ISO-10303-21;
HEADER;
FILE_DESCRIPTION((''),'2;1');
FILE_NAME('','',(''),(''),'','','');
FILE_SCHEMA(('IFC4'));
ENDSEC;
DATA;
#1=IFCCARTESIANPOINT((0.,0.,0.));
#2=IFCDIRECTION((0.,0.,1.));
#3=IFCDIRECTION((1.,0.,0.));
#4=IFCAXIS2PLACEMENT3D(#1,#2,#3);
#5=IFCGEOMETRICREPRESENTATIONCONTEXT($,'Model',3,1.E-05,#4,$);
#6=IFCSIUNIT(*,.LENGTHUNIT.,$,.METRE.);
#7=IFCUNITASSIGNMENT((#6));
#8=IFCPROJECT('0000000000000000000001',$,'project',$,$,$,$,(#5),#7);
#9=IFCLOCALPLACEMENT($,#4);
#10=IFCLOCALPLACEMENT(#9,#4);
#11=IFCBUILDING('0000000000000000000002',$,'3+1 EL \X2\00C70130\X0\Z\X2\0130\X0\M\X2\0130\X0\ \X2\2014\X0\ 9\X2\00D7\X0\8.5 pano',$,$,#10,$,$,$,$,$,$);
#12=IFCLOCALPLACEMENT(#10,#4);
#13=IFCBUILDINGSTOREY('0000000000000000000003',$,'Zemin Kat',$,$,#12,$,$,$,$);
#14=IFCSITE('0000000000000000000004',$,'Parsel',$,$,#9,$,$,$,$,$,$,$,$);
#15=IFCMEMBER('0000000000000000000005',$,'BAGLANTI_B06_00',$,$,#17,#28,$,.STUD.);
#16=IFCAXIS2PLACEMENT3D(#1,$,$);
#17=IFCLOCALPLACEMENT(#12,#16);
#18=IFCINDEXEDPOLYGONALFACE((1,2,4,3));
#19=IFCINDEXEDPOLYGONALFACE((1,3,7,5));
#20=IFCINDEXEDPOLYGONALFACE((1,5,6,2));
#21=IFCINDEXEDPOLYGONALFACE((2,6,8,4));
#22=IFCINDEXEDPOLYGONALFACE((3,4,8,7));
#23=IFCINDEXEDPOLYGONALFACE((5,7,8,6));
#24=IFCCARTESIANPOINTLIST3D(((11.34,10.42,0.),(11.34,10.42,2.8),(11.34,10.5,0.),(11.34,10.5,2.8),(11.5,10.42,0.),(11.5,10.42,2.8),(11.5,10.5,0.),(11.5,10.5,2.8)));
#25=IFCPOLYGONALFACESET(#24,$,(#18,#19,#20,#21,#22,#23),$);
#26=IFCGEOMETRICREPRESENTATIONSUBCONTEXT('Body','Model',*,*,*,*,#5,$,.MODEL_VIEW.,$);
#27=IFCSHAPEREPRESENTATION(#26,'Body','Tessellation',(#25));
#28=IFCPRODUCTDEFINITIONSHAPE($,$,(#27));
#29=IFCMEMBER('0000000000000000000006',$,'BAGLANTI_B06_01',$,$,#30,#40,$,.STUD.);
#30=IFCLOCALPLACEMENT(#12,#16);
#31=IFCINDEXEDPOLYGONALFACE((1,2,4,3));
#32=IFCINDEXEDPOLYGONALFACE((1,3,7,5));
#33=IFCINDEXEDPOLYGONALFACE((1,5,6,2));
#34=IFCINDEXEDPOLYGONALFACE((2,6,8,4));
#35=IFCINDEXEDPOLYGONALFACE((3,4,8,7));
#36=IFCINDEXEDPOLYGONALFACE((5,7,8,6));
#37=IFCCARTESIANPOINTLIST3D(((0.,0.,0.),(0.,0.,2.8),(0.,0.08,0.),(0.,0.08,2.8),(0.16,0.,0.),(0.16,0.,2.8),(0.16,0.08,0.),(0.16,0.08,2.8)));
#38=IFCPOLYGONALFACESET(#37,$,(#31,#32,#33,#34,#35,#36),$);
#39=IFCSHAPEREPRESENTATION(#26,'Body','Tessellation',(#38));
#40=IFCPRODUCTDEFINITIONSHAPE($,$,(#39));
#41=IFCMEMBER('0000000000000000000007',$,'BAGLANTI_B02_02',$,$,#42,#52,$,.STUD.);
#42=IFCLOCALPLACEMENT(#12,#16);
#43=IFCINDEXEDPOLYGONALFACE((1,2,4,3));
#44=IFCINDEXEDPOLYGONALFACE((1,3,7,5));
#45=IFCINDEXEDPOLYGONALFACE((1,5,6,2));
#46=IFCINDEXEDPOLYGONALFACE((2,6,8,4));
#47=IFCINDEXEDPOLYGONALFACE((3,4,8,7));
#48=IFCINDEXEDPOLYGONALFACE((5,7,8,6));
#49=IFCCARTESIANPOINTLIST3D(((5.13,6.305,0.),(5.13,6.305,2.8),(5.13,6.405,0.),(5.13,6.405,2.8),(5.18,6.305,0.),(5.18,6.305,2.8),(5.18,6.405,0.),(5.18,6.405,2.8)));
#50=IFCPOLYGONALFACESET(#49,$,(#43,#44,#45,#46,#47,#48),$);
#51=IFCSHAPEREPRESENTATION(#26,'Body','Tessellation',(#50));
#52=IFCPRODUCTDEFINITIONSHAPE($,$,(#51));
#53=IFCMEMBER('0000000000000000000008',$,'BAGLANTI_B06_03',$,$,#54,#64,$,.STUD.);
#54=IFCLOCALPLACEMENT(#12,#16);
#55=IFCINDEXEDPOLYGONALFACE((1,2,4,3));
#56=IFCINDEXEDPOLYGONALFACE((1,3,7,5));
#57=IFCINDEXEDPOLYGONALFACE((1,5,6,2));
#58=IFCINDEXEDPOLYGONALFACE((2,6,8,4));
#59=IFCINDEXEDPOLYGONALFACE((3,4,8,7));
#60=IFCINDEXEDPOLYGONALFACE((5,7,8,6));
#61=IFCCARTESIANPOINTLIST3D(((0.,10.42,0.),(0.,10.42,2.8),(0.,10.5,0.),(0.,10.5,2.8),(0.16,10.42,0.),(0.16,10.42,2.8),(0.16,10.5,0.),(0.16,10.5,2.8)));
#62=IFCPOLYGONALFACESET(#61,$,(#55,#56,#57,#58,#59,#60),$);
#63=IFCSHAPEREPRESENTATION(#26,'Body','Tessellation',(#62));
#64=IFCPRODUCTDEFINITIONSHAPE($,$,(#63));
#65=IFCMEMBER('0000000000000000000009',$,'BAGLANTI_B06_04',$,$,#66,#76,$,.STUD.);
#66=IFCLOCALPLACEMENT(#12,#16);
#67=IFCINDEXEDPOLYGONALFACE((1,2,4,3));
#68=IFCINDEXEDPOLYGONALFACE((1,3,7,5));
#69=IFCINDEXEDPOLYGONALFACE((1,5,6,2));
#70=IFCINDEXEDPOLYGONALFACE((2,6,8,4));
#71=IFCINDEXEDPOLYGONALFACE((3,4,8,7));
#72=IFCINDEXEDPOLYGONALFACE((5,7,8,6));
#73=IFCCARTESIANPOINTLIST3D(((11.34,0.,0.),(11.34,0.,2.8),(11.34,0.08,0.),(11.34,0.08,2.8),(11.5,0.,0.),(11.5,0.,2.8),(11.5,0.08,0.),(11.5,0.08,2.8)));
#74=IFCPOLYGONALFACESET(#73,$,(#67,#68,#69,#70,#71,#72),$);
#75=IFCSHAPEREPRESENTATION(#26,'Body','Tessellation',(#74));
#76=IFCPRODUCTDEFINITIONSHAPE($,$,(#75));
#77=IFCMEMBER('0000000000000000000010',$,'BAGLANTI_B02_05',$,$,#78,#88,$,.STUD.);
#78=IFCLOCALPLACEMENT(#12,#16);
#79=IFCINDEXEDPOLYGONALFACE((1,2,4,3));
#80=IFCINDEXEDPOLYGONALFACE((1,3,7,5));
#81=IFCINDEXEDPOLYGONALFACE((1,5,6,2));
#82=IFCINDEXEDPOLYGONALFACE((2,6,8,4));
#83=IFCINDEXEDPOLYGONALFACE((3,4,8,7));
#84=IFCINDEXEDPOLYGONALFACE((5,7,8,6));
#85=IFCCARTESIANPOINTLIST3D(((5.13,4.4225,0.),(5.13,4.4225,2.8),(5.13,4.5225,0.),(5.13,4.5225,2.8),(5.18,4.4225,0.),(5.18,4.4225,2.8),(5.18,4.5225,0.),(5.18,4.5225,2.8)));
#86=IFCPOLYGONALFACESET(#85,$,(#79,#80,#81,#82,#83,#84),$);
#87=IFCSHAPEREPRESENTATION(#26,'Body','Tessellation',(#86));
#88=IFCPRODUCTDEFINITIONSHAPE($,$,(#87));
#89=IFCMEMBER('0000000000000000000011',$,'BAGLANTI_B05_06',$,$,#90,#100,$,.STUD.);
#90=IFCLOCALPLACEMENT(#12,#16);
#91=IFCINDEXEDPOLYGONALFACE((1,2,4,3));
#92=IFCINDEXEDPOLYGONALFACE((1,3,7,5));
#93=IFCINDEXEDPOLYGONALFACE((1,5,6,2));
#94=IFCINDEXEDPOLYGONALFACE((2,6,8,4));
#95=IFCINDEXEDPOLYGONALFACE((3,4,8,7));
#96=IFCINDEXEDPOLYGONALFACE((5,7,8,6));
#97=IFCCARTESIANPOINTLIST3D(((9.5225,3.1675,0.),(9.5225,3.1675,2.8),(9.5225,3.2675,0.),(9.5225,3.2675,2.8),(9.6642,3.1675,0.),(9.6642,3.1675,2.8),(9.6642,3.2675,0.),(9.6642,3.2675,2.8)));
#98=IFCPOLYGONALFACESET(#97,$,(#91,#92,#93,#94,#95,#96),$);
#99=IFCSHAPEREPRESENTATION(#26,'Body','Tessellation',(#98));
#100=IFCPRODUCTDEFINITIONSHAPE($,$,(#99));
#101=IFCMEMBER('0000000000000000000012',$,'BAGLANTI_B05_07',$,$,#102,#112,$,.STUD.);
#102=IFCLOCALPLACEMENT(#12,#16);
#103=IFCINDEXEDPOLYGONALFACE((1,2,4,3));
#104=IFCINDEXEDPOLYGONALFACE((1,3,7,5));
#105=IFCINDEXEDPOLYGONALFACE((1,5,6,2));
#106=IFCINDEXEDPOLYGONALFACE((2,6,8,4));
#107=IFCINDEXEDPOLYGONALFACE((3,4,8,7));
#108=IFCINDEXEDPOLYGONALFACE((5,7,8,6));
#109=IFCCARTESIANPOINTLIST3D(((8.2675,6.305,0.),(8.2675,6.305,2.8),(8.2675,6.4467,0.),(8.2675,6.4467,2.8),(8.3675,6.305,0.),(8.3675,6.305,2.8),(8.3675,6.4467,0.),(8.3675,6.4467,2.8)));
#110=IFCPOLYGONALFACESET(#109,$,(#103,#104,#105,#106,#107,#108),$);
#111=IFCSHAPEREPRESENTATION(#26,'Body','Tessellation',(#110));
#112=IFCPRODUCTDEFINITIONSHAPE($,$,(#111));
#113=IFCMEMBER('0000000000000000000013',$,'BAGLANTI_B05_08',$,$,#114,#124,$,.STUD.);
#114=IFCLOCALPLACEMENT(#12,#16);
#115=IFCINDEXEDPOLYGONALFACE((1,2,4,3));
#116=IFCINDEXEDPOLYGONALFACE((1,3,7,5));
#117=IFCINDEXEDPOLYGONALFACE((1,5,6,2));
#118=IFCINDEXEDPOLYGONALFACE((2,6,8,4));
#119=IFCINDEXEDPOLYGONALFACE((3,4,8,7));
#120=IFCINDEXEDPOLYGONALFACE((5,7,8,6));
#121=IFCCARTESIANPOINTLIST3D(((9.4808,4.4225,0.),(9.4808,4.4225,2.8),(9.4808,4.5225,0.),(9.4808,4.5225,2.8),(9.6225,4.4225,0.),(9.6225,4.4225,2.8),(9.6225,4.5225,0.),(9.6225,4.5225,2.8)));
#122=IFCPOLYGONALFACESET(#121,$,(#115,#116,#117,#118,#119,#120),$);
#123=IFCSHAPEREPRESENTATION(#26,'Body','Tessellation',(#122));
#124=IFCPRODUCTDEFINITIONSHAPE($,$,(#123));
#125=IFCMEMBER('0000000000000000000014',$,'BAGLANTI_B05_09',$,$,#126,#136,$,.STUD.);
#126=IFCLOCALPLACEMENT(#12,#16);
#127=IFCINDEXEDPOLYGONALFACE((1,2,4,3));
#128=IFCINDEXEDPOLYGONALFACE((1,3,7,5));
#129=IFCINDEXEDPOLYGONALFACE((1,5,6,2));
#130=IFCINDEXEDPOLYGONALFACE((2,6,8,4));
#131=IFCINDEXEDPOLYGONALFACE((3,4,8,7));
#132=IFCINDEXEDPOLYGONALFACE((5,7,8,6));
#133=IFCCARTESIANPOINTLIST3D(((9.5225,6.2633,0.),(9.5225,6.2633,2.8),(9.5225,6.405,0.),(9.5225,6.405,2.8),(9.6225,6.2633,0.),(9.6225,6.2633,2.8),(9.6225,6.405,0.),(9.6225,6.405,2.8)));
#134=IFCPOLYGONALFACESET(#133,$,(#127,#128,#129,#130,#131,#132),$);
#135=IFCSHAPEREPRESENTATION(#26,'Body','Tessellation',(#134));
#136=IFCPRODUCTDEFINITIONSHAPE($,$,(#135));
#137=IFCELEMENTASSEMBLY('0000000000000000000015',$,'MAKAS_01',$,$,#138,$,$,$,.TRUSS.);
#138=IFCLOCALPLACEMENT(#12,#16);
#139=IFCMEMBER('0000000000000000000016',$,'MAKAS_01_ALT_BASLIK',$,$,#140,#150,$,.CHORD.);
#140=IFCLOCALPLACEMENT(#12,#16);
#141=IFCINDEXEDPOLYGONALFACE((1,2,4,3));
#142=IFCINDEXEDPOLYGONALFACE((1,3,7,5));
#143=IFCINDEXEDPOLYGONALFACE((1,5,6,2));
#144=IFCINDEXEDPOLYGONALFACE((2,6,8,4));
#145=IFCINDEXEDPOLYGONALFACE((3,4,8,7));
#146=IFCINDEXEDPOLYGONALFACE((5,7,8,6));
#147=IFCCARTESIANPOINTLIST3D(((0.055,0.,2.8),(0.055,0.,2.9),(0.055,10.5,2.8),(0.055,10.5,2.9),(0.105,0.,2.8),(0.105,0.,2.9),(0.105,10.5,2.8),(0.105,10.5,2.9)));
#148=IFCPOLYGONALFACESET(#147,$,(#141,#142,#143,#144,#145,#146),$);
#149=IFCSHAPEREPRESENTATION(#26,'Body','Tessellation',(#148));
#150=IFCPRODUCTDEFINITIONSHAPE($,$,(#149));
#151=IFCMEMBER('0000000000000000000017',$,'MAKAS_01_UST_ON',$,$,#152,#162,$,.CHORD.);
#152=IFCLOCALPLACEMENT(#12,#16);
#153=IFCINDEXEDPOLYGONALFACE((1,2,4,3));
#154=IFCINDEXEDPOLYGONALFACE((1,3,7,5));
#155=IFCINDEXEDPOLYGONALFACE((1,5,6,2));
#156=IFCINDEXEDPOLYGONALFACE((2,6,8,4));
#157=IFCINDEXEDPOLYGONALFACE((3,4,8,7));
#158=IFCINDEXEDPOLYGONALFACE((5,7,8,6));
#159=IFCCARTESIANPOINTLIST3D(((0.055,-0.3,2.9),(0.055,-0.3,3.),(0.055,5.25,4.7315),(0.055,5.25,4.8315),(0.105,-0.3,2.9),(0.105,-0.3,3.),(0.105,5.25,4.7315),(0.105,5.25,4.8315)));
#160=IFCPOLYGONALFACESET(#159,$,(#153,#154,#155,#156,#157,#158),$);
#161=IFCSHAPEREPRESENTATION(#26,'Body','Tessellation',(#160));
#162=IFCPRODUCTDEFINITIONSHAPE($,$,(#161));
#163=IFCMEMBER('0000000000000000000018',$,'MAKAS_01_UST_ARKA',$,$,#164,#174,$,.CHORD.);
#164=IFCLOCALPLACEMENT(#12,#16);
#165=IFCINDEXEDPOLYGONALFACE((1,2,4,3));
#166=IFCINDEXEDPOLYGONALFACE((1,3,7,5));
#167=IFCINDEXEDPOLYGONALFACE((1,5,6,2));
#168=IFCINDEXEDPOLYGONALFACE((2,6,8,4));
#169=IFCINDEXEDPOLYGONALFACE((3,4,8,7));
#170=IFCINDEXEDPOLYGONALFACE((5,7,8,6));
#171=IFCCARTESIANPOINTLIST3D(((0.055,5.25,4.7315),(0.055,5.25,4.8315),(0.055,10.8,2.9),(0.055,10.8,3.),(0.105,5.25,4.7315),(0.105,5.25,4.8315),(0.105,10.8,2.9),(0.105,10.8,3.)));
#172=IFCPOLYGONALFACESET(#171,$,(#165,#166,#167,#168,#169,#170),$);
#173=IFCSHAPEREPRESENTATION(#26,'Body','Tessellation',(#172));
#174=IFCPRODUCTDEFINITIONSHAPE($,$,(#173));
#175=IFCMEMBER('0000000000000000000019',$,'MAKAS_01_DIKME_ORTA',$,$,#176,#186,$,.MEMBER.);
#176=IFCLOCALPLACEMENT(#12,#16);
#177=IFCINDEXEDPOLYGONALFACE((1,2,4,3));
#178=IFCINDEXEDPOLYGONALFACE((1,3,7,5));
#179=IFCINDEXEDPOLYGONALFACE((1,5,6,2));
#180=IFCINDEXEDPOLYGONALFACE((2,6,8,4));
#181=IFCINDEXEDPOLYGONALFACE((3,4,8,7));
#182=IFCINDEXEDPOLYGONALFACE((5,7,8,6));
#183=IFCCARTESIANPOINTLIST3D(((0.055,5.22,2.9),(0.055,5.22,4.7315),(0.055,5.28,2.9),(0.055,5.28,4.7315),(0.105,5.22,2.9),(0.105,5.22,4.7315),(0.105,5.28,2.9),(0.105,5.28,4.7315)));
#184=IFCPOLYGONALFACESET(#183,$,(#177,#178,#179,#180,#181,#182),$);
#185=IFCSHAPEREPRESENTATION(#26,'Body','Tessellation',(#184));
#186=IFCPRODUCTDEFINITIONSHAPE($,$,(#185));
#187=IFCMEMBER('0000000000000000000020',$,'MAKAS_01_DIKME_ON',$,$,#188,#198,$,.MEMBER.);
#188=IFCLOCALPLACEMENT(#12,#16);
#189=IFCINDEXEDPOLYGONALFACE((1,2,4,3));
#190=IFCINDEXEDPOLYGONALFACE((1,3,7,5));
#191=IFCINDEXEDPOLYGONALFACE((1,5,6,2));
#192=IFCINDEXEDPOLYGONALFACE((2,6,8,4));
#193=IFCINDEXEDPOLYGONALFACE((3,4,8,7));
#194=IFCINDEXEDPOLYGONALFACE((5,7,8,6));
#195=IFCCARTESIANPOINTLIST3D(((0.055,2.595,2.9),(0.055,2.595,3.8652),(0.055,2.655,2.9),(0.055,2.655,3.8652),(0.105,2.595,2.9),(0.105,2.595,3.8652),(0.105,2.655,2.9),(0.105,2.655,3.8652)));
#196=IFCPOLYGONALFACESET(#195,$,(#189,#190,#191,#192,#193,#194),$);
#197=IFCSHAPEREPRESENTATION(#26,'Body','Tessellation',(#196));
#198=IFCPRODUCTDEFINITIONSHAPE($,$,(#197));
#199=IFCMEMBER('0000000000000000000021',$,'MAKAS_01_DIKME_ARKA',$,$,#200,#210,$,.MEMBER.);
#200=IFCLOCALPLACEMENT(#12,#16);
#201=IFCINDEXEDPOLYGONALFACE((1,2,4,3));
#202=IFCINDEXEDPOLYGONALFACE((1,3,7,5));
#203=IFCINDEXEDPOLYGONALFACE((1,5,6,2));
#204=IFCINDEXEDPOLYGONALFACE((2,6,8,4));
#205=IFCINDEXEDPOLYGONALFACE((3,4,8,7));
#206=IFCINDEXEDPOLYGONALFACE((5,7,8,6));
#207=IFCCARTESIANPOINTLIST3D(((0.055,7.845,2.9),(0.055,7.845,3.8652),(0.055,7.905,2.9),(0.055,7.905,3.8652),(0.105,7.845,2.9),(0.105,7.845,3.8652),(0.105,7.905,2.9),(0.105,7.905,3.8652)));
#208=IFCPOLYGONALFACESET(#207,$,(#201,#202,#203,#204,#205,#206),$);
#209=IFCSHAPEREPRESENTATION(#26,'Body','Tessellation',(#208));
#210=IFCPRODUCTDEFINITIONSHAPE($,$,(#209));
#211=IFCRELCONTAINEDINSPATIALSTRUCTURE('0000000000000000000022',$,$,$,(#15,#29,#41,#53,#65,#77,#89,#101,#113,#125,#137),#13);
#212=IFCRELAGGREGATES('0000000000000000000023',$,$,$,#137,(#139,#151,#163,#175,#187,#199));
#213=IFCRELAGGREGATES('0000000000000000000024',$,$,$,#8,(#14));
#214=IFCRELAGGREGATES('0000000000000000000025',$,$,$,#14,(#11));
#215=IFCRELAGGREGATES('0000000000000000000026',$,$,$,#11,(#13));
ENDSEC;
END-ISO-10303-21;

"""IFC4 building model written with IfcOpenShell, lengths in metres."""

from ifc_helpers import new_model, si_unit, frame, origin_with_axes, place, context, subcontext, project, spatial, line, indexed_curve, outline, extrude, element, aggregate, save


model = new_model("IFC4")

# Units and contexts
model_context = context("Model", 3, precision=1e-05, world=origin_with_axes())
body_context = subcontext(model_context, "Body", "Model", "MODEL_VIEW")
ifc_project = project(units=[si_unit("LENGTHUNIT", "METRE")], contexts=[model_context])

# Site, building, storey
site_placement = place(None, origin_with_axes())
site = spatial("IfcSite", under=ifc_project, at=site_placement, Name="Parsel")
building_placement = place(site_placement, origin_with_axes())
building = spatial("IfcBuilding", under=site, at=building_placement, Name="3+1 EL ÇİZİMİ — 9×8.5 pano")
storey_placement = place(building_placement, origin_with_axes())
storey = spatial("IfcBuildingStorey", under=building, at=storey_placement, Name="Zemin Kat")

# Members
member_1_placement = place(storey_placement, origin_with_axes())
element("IfcMember", 1, at=member_1_placement, inside=storey, Name="BAGLANTI_B06_00", PredefinedType="STUD", context=body_context, shape_type="SweptSolid", body=[
    extrude(outline(indexed_curve([(11.34, 10.42), (11.5, 10.42), (11.5, 10.5), (11.34, 10.5)], segments=[line(1, 2, 3, 4, 1)])), origin_with_axes(), (0.0, 0.0, 1.0), 2.8),
])
member_2_placement = place(storey_placement, origin_with_axes())
element("IfcMember", 2, at=member_2_placement, inside=storey, Name="BAGLANTI_B06_01", PredefinedType="STUD", context=body_context, shape_type="SweptSolid", body=[
    extrude(outline(indexed_curve([(0.0, 0.0), (0.16, 0.0), (0.16, 0.08), (0.0, 0.08)], segments=[line(1, 2, 3, 4, 1)])), origin_with_axes(), (0.0, 0.0, 1.0), 2.8),
])
member_3_placement = place(storey_placement, origin_with_axes())
element("IfcMember", 3, at=member_3_placement, inside=storey, Name="BAGLANTI_B02_02", PredefinedType="STUD", context=body_context, shape_type="SweptSolid", body=[
    extrude(outline(indexed_curve([(5.13, 6.305), (5.18, 6.305), (5.18, 6.405), (5.13, 6.405)], segments=[line(1, 2, 3, 4, 1)])), origin_with_axes(), (0.0, 0.0, 1.0), 2.8),
])
member_4_placement = place(storey_placement, origin_with_axes())
element("IfcMember", 4, at=member_4_placement, inside=storey, Name="BAGLANTI_B06_03", PredefinedType="STUD", context=body_context, shape_type="SweptSolid", body=[
    extrude(outline(indexed_curve([(0.0, 10.42), (0.16, 10.42), (0.16, 10.5), (0.0, 10.5)], segments=[line(1, 2, 3, 4, 1)])), origin_with_axes(), (0.0, 0.0, 1.0), 2.8),
])
member_5_placement = place(storey_placement, origin_with_axes())
element("IfcMember", 5, at=member_5_placement, inside=storey, Name="BAGLANTI_B06_04", PredefinedType="STUD", context=body_context, shape_type="SweptSolid", body=[
    extrude(outline(indexed_curve([(11.34, 0.0), (11.5, 0.0), (11.5, 0.08), (11.34, 0.08)], segments=[line(1, 2, 3, 4, 1)])), origin_with_axes(), (0.0, 0.0, 1.0), 2.8),
])
member_6_placement = place(storey_placement, origin_with_axes())
element("IfcMember", 6, at=member_6_placement, inside=storey, Name="BAGLANTI_B02_05", PredefinedType="STUD", context=body_context, shape_type="SweptSolid", body=[
    extrude(outline(indexed_curve([(5.13, 4.4225), (5.18, 4.4225), (5.18, 4.5225), (5.13, 4.5225)], segments=[line(1, 2, 3, 4, 1)])), origin_with_axes(), (0.0, 0.0, 1.0), 2.8),
])
member_7_placement = place(storey_placement, origin_with_axes())
element("IfcMember", 7, at=member_7_placement, inside=storey, Name="BAGLANTI_B05_06", PredefinedType="STUD", context=body_context, shape_type="SweptSolid", body=[
    extrude(outline(indexed_curve([(9.5225, 3.1675), (9.6642, 3.1675), (9.6642, 3.2675), (9.5225, 3.2675)], segments=[line(1, 2, 3, 4, 1)])), origin_with_axes(), (0.0, 0.0, 1.0), 2.8),
])
member_8_placement = place(storey_placement, origin_with_axes())
element("IfcMember", 8, at=member_8_placement, inside=storey, Name="BAGLANTI_B05_07", PredefinedType="STUD", context=body_context, shape_type="SweptSolid", body=[
    extrude(outline(indexed_curve([(8.2675, 6.305), (8.3675, 6.305), (8.3675, 6.4467), (8.2675, 6.4467)], segments=[line(1, 2, 3, 4, 1)])), origin_with_axes(), (0.0, 0.0, 1.0), 2.8),
])
member_9_placement = place(storey_placement, origin_with_axes())
element("IfcMember", 9, at=member_9_placement, inside=storey, Name="BAGLANTI_B05_08", PredefinedType="STUD", context=body_context, shape_type="SweptSolid", body=[
    extrude(outline(indexed_curve([(9.4808, 4.4225), (9.6225, 4.4225), (9.6225, 4.5225), (9.4808, 4.5225)], segments=[line(1, 2, 3, 4, 1)])), origin_with_axes(), (0.0, 0.0, 1.0), 2.8),
])
member_10_placement = place(storey_placement, origin_with_axes())
element("IfcMember", 10, at=member_10_placement, inside=storey, Name="BAGLANTI_B05_09", PredefinedType="STUD", context=body_context, shape_type="SweptSolid", body=[
    extrude(outline(indexed_curve([(9.5225, 6.2633), (9.6225, 6.2633), (9.6225, 6.405), (9.5225, 6.405)], segments=[line(1, 2, 3, 4, 1)])), origin_with_axes(), (0.0, 0.0, 1.0), 2.8),
])

# Element assembly, members
assembly_1_placement = place(storey_placement, origin_with_axes())
assembly_1 = element("IfcElementAssembly", 11, at=assembly_1_placement, inside=storey, Name="MAKAS_01", PredefinedType="TRUSS")
member_11_placement = place(assembly_1_placement, origin_with_axes())
member_11 = element("IfcMember", 12, at=member_11_placement, Name="MAKAS_01_ALT_BASLIK", PredefinedType="CHORD", context=body_context, shape_type="SweptSolid", body=[
    extrude(outline(indexed_curve([(0.0, 2.8), (10.5, 2.8), (10.5, 2.9), (0.0, 2.9)], segments=[line(1, 2, 3, 4, 1)])), frame((0.055, 0.0, 0.0), z_axis=(1.0, 0.0, 0.0), x_axis=(0.0, 1.0, 0.0)), (0.0, 0.0, 1.0), 0.05),
])
member_12_placement = place(assembly_1_placement, origin_with_axes())
member_12 = element("IfcMember", 13, at=member_12_placement, Name="MAKAS_01_UST_ON", PredefinedType="CHORD", context=body_context, shape_type="SweptSolid", body=[
    extrude(outline(indexed_curve([(-0.3, 2.9), (5.25, 4.7315), (5.25, 4.8315), (-0.3, 3.0)], segments=[line(1, 2, 3, 4, 1)])), frame((0.055, 0.0, 0.0), z_axis=(1.0, 0.0, 0.0), x_axis=(0.0, 1.0, 0.0)), (0.0, 0.0, 1.0), 0.05),
])
member_13_placement = place(assembly_1_placement, origin_with_axes())
member_13 = element("IfcMember", 14, at=member_13_placement, Name="MAKAS_01_UST_ARKA", PredefinedType="CHORD", context=body_context, shape_type="SweptSolid", body=[
    extrude(outline(indexed_curve([(5.25, 4.7315), (10.8, 2.9), (10.8, 3.0), (5.25, 4.8315)], segments=[line(1, 2, 3, 4, 1)])), frame((0.055, 0.0, 0.0), z_axis=(1.0, 0.0, 0.0), x_axis=(0.0, 1.0, 0.0)), (0.0, 0.0, 1.0), 0.05),
])
member_14_placement = place(assembly_1_placement, origin_with_axes())
member_14 = element("IfcMember", 15, at=member_14_placement, Name="MAKAS_01_DIKME_ORTA", PredefinedType="MEMBER", context=body_context, shape_type="SweptSolid", body=[
    extrude(outline(indexed_curve([(5.22, 2.9), (5.28, 2.9), (5.28, 4.7315), (5.22, 4.7315)], segments=[line(1, 2, 3, 4, 1)])), frame((0.055, 0.0, 0.0), z_axis=(1.0, 0.0, 0.0), x_axis=(0.0, 1.0, 0.0)), (0.0, 0.0, 1.0), 0.05),
])
member_15_placement = place(assembly_1_placement, origin_with_axes())
member_15 = element("IfcMember", 16, at=member_15_placement, Name="MAKAS_01_DIKME_ON", PredefinedType="MEMBER", context=body_context, shape_type="SweptSolid", body=[
    extrude(outline(indexed_curve([(2.595, 2.9), (2.655, 2.9), (2.655, 3.8653), (2.595, 3.8653)], segments=[line(1, 2, 3, 4, 1)])), frame((0.055, 0.0, 0.0), z_axis=(1.0, 0.0, 0.0), x_axis=(0.0, 1.0, 0.0)), (0.0, 0.0, 1.0), 0.05),
])
member_16_placement = place(assembly_1_placement, origin_with_axes())
member_16 = element("IfcMember", 17, at=member_16_placement, Name="MAKAS_01_DIKME_ARKA", PredefinedType="MEMBER", context=body_context, shape_type="SweptSolid", body=[
    extrude(outline(indexed_curve([(7.845, 2.9), (7.905, 2.9), (7.905, 3.8653), (7.845, 3.8653)], segments=[line(1, 2, 3, 4, 1)])), frame((0.055, 0.0, 0.0), z_axis=(1.0, 0.0, 0.0), x_axis=(0.0, 1.0, 0.0)), (0.0, 0.0, 1.0), 0.05),
])
aggregate(assembly_1, [member_11, member_12, member_13, member_14, member_15, member_16])

save(model, "model.ifc")
